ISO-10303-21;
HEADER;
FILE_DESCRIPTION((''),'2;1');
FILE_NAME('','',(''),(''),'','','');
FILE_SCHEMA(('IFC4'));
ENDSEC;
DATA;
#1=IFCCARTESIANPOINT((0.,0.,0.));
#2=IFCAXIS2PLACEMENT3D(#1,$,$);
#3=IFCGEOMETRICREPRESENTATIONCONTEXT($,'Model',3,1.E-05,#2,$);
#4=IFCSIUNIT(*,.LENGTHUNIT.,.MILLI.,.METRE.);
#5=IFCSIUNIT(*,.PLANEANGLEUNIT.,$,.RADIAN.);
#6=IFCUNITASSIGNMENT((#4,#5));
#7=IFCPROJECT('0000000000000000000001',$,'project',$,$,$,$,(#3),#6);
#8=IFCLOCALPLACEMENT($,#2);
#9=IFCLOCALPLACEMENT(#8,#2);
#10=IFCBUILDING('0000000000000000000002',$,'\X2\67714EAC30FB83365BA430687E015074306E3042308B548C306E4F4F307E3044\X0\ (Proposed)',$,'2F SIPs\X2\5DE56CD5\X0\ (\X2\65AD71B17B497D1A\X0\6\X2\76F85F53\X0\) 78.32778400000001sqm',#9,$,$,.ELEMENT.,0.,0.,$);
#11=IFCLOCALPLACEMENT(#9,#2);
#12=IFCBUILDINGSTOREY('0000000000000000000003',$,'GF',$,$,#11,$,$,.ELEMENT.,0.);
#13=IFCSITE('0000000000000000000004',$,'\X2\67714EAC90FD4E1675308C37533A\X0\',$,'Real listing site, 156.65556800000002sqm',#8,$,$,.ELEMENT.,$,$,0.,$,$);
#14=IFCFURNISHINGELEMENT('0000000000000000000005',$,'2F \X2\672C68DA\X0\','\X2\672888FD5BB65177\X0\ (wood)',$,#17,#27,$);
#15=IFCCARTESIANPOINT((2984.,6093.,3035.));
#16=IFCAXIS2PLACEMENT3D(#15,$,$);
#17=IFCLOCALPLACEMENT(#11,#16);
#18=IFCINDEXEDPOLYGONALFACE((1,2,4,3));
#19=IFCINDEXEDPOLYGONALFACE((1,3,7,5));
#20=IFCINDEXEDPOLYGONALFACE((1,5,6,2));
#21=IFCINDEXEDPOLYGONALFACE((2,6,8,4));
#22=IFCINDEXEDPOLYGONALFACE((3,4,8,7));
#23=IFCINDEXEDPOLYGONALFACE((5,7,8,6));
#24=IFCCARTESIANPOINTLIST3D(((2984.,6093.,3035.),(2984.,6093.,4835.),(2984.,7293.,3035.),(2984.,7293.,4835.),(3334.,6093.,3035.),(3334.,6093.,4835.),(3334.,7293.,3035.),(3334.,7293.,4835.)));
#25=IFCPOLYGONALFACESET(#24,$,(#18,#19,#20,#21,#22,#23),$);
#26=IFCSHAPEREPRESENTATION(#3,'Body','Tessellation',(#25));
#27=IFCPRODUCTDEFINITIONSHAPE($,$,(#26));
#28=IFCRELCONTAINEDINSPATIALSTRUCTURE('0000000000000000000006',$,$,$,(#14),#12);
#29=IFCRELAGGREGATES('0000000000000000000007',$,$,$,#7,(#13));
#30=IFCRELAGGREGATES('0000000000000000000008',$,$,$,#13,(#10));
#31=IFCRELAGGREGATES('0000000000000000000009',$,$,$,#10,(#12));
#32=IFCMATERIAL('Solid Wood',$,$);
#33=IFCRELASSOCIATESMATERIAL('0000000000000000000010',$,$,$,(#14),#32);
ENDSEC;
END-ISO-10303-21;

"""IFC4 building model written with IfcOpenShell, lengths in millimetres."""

from ifc_helpers import new_model, si_unit, frame, frame_2d, origin, place, context, project, spatial, rectangle, extrude, material, element, save


model = new_model("IFC4")

# Units and contexts
model_context = context("Model", 3, precision=1e-05, world=origin())
ifc_project = project(units=[si_unit("LENGTHUNIT", "METRE", prefix="MILLI"), si_unit("PLANEANGLEUNIT", "RADIAN")], contexts=[model_context])

# Site, building, storey
site_placement = place(None, origin())
site = spatial("IfcSite", under=ifc_project, at=site_placement, Name="東京都世田谷区", ObjectType="Real listing site, 156.65556800000002sqm", CompositionType="ELEMENT", RefElevation=0.0)
building_placement = place(site_placement, origin())
building = spatial("IfcBuilding", under=site, at=building_placement, Name="東京・茶室と縁側のある和の住まい (Proposed)", ObjectType="2F SIPs工法 (断熱等級6相当) 78.32778400000001sqm", CompositionType="ELEMENT", ElevationOfRefHeight=0.0, ElevationOfTerrain=0.0)
storey_placement = place(building_placement, origin())
storey = spatial("IfcBuildingStorey", under=building, at=storey_placement, Name="GF", CompositionType="ELEMENT", Elevation=0.0)

# Shared definitions
ifc_material_1 = material(Name="Solid Wood")

# Furnishing element
furnishing_1_placement = place(storey_placement, frame((2984.0, 6093.0, 3035.0)))
element("IfcFurnishingElement", 1, at=furnishing_1_placement, inside=storey, material=ifc_material_1, Name="2F 本棚", Description="木製家具 (wood)", context=model_context, shape_type="SweptSolid", body=[
    extrude(rectangle(XDim=350.0, YDim=1200.0, at=frame_2d((175.0, 600.0))), frame((2984.0, 6093.0, 3035.0)), (0.0, 0.0, 1.0), 1800.0),
])

save(model, "model.ifc")
